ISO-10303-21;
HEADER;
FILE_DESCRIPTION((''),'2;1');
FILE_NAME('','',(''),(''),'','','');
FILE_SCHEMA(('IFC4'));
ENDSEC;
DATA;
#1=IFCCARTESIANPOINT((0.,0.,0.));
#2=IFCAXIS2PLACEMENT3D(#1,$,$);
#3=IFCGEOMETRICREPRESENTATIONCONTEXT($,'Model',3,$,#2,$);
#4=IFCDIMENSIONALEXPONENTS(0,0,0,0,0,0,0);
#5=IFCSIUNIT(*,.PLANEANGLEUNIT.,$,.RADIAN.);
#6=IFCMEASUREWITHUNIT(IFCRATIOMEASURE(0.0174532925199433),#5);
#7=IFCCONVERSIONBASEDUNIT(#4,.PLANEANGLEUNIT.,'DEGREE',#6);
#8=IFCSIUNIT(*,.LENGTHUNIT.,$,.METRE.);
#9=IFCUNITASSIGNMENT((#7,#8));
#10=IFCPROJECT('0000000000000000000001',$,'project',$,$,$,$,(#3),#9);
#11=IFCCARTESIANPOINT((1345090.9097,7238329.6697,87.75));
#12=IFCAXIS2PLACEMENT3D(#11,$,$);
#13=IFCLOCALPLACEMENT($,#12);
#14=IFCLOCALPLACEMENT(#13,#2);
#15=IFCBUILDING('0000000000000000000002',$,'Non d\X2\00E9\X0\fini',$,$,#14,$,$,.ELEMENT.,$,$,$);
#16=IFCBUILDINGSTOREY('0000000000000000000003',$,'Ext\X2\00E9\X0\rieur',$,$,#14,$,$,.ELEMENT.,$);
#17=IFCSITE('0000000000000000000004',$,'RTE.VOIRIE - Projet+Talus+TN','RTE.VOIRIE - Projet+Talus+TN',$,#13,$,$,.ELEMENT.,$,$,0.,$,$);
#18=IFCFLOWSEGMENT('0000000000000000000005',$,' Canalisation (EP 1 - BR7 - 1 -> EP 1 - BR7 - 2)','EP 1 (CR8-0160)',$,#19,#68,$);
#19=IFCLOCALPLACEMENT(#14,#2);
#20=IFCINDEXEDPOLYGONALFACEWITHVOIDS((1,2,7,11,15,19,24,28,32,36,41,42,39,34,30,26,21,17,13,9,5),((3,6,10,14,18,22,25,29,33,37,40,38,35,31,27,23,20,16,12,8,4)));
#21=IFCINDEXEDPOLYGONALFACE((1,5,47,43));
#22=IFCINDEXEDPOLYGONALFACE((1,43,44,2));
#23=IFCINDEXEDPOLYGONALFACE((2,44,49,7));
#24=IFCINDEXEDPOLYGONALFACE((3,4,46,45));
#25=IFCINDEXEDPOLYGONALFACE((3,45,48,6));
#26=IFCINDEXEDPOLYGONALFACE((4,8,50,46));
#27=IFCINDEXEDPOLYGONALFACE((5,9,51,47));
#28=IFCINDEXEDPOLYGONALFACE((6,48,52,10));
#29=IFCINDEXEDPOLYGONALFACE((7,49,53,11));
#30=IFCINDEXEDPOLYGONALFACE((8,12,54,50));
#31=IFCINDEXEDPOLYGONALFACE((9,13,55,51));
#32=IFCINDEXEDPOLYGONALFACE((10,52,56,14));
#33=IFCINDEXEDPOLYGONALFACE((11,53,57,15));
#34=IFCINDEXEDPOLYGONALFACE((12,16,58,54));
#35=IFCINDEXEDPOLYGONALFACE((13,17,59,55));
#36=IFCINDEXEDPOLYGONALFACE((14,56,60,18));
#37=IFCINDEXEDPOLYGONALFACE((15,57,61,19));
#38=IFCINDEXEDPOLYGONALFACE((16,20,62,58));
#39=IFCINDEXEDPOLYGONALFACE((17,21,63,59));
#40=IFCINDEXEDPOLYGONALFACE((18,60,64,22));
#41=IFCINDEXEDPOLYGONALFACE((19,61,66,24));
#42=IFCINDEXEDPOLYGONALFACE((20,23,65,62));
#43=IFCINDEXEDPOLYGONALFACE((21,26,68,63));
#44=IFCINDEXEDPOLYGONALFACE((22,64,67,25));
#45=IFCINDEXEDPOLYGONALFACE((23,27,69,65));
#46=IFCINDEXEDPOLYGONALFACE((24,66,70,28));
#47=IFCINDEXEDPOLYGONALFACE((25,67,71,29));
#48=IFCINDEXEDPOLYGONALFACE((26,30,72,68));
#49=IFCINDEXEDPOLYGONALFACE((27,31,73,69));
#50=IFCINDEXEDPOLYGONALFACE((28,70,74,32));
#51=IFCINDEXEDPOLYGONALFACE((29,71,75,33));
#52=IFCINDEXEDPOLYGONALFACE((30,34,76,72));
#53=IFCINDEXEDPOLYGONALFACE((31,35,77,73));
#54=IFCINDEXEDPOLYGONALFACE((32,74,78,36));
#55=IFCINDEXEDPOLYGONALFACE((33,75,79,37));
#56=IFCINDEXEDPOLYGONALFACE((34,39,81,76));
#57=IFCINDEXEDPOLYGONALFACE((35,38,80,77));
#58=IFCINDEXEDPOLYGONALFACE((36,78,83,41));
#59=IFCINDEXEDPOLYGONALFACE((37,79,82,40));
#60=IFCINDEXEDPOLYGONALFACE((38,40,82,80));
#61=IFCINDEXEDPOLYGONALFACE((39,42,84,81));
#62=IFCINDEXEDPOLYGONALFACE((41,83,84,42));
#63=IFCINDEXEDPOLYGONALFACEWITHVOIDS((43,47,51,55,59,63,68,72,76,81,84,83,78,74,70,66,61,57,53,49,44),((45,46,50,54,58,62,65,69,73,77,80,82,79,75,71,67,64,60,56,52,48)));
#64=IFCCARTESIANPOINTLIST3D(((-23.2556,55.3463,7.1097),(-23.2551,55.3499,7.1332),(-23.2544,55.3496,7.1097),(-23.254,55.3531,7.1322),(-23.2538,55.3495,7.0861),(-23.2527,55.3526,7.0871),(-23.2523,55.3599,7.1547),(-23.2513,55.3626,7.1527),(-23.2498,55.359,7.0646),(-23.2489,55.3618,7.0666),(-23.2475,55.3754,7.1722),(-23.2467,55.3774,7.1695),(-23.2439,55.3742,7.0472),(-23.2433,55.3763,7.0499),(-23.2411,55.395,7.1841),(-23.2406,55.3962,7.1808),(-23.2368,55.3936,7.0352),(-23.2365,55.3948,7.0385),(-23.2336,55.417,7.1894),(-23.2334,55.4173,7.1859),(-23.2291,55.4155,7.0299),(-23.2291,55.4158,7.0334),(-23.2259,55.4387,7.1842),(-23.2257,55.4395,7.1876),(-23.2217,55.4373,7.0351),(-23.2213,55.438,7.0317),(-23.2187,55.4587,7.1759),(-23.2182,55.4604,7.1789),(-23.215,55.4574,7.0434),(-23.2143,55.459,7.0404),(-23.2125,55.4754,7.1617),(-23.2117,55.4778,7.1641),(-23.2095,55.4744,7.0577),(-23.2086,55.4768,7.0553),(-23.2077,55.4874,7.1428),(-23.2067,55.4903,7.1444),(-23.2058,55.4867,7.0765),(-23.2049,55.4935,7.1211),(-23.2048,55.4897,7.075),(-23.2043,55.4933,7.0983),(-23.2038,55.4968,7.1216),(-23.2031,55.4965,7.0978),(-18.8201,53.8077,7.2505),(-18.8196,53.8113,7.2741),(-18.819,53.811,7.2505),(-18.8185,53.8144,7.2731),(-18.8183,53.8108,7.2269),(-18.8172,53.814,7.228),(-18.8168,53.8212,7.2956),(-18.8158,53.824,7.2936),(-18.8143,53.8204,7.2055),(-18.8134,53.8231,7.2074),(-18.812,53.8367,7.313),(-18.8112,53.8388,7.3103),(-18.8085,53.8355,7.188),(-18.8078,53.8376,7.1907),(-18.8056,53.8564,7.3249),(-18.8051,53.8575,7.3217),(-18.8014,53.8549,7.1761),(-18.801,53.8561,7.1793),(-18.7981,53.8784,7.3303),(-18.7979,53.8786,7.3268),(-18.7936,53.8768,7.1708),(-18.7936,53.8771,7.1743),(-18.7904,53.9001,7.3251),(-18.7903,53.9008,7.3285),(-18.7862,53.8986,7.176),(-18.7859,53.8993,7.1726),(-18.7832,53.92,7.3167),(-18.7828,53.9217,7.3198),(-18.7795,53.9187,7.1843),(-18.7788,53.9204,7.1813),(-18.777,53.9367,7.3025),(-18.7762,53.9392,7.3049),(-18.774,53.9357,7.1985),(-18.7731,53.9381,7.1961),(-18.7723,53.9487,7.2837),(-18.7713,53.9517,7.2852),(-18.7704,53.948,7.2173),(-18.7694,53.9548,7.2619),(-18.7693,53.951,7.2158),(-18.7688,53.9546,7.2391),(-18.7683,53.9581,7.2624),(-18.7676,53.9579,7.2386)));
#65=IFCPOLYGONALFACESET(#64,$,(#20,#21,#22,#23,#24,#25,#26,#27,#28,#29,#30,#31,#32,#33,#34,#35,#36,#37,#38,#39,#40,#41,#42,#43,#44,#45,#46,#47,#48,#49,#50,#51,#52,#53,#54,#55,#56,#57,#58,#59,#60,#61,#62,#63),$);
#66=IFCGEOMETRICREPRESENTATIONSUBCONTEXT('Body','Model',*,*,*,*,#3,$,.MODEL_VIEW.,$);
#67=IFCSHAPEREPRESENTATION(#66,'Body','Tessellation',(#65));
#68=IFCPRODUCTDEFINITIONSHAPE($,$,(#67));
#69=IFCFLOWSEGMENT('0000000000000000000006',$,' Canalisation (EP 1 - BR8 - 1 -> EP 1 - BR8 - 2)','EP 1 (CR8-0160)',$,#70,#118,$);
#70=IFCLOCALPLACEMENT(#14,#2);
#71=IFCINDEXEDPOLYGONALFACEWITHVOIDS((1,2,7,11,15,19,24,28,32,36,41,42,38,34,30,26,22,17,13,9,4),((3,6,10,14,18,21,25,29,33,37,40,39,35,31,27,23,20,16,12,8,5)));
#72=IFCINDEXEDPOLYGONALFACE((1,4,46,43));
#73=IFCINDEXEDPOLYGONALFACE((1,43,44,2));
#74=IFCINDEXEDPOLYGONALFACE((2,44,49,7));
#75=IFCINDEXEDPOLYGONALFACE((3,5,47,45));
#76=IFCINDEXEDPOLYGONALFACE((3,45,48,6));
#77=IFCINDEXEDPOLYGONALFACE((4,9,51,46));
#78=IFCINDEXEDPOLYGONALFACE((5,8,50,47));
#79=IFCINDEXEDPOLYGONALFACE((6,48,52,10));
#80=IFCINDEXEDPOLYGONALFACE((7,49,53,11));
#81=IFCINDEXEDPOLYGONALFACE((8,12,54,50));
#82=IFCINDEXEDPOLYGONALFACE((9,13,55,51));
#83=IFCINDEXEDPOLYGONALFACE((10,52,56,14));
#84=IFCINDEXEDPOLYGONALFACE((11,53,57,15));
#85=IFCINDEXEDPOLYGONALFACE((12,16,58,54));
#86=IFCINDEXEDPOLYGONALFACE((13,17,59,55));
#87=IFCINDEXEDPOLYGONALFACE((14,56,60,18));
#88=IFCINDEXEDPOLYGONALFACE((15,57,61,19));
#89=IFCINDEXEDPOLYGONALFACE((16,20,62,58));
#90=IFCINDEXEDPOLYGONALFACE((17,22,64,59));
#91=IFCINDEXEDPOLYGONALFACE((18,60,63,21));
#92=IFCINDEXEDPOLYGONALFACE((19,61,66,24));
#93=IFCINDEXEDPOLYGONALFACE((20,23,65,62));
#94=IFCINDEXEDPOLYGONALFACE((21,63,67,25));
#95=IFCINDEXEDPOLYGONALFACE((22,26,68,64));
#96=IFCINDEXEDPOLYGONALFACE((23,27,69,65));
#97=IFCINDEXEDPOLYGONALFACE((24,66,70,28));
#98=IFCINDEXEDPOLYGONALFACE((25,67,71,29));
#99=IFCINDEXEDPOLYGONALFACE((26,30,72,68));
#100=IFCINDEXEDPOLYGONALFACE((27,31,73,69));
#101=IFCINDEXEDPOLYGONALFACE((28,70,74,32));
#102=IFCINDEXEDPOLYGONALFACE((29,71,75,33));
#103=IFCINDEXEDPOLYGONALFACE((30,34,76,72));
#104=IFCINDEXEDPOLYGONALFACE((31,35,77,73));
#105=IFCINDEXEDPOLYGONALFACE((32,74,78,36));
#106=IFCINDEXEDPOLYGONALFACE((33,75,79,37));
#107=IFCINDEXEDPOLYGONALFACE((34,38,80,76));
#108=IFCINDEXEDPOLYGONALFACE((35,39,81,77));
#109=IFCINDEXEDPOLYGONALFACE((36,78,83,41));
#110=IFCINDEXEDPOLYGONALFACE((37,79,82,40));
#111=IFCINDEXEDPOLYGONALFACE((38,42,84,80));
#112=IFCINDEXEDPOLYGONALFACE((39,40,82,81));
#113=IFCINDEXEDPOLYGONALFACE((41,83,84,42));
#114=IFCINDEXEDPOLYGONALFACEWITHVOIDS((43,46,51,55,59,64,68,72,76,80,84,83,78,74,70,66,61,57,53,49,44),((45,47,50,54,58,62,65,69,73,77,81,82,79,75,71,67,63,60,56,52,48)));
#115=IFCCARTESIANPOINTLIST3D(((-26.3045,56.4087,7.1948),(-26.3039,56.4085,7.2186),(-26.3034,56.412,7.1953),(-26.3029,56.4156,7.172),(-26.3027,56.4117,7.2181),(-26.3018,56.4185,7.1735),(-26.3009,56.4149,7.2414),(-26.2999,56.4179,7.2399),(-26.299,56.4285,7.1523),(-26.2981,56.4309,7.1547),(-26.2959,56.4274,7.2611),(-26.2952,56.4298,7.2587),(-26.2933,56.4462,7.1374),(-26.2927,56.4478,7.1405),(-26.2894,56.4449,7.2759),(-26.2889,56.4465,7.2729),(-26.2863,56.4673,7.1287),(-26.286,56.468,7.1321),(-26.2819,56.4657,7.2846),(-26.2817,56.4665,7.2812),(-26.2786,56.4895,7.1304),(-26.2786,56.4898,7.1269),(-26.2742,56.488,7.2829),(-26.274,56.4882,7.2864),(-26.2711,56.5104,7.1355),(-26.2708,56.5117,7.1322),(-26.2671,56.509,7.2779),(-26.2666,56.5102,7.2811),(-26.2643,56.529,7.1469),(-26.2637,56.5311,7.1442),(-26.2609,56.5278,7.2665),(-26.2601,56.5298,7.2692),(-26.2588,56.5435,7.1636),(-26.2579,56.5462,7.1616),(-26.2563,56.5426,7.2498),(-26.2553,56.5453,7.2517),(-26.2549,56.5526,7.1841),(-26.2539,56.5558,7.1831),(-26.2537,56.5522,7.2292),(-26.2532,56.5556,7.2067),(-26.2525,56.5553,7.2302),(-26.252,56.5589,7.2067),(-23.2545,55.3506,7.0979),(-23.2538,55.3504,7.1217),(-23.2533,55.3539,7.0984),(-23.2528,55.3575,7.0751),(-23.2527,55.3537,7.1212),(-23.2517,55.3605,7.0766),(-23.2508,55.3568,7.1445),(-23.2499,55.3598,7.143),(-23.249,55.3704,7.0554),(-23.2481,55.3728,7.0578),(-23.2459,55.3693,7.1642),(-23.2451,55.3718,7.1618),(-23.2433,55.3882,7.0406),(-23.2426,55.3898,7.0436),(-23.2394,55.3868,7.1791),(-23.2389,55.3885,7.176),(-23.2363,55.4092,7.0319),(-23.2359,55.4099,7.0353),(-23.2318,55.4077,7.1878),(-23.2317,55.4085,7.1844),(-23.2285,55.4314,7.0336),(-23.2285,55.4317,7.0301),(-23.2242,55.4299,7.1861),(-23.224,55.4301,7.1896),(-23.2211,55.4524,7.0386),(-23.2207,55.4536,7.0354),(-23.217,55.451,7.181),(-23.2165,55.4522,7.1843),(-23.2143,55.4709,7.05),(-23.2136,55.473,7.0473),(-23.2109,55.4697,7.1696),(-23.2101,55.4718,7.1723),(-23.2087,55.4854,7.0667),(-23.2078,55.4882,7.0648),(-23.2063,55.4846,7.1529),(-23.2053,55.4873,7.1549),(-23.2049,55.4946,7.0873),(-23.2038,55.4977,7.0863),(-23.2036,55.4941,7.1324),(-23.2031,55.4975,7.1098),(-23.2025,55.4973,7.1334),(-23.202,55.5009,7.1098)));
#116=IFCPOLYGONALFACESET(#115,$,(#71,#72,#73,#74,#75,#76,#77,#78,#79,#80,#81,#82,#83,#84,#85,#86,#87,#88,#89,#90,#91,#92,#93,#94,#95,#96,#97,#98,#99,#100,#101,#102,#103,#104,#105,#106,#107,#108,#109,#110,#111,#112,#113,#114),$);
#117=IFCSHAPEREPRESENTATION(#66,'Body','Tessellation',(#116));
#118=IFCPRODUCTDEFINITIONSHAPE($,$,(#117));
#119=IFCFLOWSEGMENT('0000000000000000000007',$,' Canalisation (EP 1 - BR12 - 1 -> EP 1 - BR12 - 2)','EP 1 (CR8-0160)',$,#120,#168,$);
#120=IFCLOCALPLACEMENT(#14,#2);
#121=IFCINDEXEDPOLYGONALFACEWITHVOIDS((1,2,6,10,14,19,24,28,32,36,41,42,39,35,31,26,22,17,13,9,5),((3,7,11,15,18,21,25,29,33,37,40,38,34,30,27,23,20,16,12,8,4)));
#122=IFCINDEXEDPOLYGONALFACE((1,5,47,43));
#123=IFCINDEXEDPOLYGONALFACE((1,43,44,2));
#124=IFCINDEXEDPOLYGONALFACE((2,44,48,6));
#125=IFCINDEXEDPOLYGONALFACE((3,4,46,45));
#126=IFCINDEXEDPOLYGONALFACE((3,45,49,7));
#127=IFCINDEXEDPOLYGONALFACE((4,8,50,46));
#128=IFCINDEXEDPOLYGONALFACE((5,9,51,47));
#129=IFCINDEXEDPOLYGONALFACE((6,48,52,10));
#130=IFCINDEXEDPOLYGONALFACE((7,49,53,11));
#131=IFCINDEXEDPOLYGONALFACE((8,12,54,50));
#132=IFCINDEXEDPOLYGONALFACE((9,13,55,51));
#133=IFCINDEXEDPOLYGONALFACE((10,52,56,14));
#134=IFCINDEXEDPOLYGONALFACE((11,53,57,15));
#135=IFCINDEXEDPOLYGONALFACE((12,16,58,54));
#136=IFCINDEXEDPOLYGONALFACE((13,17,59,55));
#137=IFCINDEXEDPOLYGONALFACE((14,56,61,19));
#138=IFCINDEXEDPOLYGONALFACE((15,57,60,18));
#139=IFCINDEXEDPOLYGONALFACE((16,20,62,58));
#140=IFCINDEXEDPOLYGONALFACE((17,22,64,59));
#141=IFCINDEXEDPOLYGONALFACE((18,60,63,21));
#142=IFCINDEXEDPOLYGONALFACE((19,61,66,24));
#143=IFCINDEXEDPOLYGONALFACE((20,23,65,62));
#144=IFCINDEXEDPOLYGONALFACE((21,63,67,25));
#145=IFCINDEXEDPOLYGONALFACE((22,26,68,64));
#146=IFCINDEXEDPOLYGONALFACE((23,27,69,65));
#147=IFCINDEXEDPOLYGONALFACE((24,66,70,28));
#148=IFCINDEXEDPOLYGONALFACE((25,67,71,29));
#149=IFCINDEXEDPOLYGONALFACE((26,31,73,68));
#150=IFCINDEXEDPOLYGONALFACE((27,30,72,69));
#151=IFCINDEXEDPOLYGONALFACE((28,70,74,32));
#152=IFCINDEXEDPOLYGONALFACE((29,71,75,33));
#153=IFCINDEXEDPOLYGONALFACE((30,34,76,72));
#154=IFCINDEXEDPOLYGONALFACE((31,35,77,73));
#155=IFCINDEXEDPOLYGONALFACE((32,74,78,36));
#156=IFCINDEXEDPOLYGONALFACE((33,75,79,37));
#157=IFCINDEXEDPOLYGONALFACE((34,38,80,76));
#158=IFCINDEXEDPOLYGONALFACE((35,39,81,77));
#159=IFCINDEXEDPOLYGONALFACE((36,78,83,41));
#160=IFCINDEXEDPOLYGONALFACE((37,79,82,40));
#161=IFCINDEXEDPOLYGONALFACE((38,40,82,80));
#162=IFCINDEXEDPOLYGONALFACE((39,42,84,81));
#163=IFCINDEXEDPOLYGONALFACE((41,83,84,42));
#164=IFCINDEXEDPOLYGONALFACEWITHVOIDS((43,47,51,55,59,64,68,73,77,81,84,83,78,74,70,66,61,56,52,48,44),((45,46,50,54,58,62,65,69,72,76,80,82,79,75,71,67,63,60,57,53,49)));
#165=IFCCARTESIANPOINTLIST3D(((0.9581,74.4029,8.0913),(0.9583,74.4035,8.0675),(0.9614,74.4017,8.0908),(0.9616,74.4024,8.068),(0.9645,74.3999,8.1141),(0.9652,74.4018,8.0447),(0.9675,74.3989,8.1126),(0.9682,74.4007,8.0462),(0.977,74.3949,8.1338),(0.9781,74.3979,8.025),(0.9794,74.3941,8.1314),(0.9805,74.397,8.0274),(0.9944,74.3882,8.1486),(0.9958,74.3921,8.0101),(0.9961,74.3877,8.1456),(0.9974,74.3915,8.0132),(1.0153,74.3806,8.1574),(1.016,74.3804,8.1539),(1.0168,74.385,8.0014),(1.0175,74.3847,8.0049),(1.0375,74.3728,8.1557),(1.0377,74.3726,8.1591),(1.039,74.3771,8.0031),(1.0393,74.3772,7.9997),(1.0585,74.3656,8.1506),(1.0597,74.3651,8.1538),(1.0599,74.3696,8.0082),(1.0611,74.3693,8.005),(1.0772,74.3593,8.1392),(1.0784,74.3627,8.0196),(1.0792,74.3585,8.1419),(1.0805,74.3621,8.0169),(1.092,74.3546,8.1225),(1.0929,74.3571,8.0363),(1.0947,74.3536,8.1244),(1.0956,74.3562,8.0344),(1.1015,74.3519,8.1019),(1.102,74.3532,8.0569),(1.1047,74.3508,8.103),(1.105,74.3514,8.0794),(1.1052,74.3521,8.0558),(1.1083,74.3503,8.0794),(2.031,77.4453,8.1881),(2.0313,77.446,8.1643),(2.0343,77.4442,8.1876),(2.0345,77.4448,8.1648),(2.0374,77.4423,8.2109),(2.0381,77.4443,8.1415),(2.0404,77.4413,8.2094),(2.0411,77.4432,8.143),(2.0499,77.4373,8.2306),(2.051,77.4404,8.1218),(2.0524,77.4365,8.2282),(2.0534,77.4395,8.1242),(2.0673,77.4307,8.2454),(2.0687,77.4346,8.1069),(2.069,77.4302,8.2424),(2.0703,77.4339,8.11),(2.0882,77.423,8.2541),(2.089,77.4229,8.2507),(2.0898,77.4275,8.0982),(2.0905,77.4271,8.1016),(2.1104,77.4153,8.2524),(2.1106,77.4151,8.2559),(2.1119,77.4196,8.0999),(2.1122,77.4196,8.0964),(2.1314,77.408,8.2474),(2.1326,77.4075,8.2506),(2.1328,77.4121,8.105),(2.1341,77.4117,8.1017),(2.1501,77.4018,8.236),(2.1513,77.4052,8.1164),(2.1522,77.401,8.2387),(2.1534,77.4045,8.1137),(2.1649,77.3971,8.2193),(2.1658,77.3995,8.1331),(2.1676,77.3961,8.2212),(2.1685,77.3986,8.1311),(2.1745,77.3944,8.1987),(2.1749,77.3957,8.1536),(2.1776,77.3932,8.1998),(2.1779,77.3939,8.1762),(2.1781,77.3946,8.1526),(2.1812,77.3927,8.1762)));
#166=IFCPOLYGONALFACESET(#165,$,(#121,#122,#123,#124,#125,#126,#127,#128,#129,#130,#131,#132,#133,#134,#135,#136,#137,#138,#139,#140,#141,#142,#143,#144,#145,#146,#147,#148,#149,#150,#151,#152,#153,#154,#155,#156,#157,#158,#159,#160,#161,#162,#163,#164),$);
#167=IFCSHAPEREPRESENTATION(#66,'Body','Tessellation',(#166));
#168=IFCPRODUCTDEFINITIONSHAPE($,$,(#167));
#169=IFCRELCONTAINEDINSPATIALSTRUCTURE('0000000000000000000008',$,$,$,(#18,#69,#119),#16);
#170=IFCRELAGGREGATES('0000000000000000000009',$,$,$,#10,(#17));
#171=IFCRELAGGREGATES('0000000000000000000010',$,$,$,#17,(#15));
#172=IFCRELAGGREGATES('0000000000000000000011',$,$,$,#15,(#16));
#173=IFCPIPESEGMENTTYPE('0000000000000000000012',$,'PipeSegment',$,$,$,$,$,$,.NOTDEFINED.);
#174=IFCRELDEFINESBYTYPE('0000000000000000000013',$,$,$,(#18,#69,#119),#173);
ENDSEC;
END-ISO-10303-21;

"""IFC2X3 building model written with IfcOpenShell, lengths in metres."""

from ifc_helpers import new_model, entity, si_unit, converted_unit, frame, origin, origin_2d_with_axis, place, context, subcontext, project, spatial, hollow_circle, extrude, type_object, element, save


model = new_model("IFC2X3")

# Units and contexts
model_context = context("Model", 3, world=origin())
body_context = subcontext(model_context, "Body", "Model", "MODEL_VIEW")
ifc_project = project(units=[converted_unit("PLANEANGLEUNIT", "DEGREE", entity("IfcRatioMeasure", 0.0174532925199433), si_unit("PLANEANGLEUNIT", "RADIAN"), dimensions=[0, 0, 0, 0, 0, 0, 0]), si_unit("LENGTHUNIT", "METRE")], contexts=[model_context])

# Site, building, storey
site_placement = place(None, frame((1345090.9097, 7238329.6697, 87.75)))
site = spatial("IfcSite", under=ifc_project, at=site_placement, Name="RTE.VOIRIE - Projet+Talus+TN", Description="RTE.VOIRIE - Projet+Talus+TN", CompositionType="ELEMENT", RefElevation=0.0)
placement = place(site_placement, origin())
building = spatial("IfcBuilding", under=site, at=placement, Name="Non défini", CompositionType="ELEMENT")
storey = spatial("IfcBuildingStorey", under=building, at=placement, Name="Extérieur", CompositionType="ELEMENT")

# Flow segments
pipe_segment_type_1 = type_object("IfcPipeSegmentType", Name="PipeSegment", PredefinedType="NOTDEFINED")
flow_segment_1_placement = place(placement, origin())
element("IfcFlowSegment", 1, at=flow_segment_1_placement, inside=storey, type_object=pipe_segment_type_1, Name=" Canalisation (EP 1 - BR7 - 1 -> EP 1 - BR7 - 2)", Description="EP 1 (CR8-0160)", context=body_context, shape_type="SweptSolid", body=[
    extrude(hollow_circle(Radius=0.08, WallThickness=0.0035, at=origin_2d_with_axis()), frame((-18.7939, 53.8833, 7.2505), z_axis=(-0.944344, 0.32759, -0.029987), x_axis=(-0.32759, -0.944344, 0.0)), (0.0, 0.0, 1.0), 4.6969),
])
flow_segment_2_placement = place(placement, origin())
element("IfcFlowSegment", 2, at=flow_segment_2_placement, inside=storey, type_object=pipe_segment_type_1, Name=" Canalisation (EP 1 - BR8 - 1 -> EP 1 - BR8 - 2)", Description="EP 1 (CR8-0160)", context=body_context, shape_type="SweptSolid", body=[
    extrude(hollow_circle(Radius=0.08, WallThickness=0.0035, at=origin_2d_with_axis()), frame((-26.2783, 56.4833, 7.2067), z_axis=(0.944344, -0.32759, -0.029987), x_axis=(0.32759, 0.944344, 0.0)), (0.0, 0.0, 1.0), 3.2298),
])
flow_segment_3_placement = place(placement, origin())
element("IfcFlowSegment", 3, at=flow_segment_3_placement, inside=storey, type_object=pipe_segment_type_1, Name=" Canalisation (EP 1 - BR12 - 1 -> EP 1 - BR12 - 2)", Description="EP 1 (CR8-0160)", context=body_context, shape_type="SweptSolid", body=[
    extrude(hollow_circle(Radius=0.08, WallThickness=0.0035, at=origin_2d_with_axis()), frame((2.1058, 77.4193, 8.1762), z_axis=(-0.332429, -0.942651, -0.029987), x_axis=(0.942651, -0.332429, 0.0)), (0.0, 0.0, 1.0), 3.2275),
])

save(model, "model.ifc")
